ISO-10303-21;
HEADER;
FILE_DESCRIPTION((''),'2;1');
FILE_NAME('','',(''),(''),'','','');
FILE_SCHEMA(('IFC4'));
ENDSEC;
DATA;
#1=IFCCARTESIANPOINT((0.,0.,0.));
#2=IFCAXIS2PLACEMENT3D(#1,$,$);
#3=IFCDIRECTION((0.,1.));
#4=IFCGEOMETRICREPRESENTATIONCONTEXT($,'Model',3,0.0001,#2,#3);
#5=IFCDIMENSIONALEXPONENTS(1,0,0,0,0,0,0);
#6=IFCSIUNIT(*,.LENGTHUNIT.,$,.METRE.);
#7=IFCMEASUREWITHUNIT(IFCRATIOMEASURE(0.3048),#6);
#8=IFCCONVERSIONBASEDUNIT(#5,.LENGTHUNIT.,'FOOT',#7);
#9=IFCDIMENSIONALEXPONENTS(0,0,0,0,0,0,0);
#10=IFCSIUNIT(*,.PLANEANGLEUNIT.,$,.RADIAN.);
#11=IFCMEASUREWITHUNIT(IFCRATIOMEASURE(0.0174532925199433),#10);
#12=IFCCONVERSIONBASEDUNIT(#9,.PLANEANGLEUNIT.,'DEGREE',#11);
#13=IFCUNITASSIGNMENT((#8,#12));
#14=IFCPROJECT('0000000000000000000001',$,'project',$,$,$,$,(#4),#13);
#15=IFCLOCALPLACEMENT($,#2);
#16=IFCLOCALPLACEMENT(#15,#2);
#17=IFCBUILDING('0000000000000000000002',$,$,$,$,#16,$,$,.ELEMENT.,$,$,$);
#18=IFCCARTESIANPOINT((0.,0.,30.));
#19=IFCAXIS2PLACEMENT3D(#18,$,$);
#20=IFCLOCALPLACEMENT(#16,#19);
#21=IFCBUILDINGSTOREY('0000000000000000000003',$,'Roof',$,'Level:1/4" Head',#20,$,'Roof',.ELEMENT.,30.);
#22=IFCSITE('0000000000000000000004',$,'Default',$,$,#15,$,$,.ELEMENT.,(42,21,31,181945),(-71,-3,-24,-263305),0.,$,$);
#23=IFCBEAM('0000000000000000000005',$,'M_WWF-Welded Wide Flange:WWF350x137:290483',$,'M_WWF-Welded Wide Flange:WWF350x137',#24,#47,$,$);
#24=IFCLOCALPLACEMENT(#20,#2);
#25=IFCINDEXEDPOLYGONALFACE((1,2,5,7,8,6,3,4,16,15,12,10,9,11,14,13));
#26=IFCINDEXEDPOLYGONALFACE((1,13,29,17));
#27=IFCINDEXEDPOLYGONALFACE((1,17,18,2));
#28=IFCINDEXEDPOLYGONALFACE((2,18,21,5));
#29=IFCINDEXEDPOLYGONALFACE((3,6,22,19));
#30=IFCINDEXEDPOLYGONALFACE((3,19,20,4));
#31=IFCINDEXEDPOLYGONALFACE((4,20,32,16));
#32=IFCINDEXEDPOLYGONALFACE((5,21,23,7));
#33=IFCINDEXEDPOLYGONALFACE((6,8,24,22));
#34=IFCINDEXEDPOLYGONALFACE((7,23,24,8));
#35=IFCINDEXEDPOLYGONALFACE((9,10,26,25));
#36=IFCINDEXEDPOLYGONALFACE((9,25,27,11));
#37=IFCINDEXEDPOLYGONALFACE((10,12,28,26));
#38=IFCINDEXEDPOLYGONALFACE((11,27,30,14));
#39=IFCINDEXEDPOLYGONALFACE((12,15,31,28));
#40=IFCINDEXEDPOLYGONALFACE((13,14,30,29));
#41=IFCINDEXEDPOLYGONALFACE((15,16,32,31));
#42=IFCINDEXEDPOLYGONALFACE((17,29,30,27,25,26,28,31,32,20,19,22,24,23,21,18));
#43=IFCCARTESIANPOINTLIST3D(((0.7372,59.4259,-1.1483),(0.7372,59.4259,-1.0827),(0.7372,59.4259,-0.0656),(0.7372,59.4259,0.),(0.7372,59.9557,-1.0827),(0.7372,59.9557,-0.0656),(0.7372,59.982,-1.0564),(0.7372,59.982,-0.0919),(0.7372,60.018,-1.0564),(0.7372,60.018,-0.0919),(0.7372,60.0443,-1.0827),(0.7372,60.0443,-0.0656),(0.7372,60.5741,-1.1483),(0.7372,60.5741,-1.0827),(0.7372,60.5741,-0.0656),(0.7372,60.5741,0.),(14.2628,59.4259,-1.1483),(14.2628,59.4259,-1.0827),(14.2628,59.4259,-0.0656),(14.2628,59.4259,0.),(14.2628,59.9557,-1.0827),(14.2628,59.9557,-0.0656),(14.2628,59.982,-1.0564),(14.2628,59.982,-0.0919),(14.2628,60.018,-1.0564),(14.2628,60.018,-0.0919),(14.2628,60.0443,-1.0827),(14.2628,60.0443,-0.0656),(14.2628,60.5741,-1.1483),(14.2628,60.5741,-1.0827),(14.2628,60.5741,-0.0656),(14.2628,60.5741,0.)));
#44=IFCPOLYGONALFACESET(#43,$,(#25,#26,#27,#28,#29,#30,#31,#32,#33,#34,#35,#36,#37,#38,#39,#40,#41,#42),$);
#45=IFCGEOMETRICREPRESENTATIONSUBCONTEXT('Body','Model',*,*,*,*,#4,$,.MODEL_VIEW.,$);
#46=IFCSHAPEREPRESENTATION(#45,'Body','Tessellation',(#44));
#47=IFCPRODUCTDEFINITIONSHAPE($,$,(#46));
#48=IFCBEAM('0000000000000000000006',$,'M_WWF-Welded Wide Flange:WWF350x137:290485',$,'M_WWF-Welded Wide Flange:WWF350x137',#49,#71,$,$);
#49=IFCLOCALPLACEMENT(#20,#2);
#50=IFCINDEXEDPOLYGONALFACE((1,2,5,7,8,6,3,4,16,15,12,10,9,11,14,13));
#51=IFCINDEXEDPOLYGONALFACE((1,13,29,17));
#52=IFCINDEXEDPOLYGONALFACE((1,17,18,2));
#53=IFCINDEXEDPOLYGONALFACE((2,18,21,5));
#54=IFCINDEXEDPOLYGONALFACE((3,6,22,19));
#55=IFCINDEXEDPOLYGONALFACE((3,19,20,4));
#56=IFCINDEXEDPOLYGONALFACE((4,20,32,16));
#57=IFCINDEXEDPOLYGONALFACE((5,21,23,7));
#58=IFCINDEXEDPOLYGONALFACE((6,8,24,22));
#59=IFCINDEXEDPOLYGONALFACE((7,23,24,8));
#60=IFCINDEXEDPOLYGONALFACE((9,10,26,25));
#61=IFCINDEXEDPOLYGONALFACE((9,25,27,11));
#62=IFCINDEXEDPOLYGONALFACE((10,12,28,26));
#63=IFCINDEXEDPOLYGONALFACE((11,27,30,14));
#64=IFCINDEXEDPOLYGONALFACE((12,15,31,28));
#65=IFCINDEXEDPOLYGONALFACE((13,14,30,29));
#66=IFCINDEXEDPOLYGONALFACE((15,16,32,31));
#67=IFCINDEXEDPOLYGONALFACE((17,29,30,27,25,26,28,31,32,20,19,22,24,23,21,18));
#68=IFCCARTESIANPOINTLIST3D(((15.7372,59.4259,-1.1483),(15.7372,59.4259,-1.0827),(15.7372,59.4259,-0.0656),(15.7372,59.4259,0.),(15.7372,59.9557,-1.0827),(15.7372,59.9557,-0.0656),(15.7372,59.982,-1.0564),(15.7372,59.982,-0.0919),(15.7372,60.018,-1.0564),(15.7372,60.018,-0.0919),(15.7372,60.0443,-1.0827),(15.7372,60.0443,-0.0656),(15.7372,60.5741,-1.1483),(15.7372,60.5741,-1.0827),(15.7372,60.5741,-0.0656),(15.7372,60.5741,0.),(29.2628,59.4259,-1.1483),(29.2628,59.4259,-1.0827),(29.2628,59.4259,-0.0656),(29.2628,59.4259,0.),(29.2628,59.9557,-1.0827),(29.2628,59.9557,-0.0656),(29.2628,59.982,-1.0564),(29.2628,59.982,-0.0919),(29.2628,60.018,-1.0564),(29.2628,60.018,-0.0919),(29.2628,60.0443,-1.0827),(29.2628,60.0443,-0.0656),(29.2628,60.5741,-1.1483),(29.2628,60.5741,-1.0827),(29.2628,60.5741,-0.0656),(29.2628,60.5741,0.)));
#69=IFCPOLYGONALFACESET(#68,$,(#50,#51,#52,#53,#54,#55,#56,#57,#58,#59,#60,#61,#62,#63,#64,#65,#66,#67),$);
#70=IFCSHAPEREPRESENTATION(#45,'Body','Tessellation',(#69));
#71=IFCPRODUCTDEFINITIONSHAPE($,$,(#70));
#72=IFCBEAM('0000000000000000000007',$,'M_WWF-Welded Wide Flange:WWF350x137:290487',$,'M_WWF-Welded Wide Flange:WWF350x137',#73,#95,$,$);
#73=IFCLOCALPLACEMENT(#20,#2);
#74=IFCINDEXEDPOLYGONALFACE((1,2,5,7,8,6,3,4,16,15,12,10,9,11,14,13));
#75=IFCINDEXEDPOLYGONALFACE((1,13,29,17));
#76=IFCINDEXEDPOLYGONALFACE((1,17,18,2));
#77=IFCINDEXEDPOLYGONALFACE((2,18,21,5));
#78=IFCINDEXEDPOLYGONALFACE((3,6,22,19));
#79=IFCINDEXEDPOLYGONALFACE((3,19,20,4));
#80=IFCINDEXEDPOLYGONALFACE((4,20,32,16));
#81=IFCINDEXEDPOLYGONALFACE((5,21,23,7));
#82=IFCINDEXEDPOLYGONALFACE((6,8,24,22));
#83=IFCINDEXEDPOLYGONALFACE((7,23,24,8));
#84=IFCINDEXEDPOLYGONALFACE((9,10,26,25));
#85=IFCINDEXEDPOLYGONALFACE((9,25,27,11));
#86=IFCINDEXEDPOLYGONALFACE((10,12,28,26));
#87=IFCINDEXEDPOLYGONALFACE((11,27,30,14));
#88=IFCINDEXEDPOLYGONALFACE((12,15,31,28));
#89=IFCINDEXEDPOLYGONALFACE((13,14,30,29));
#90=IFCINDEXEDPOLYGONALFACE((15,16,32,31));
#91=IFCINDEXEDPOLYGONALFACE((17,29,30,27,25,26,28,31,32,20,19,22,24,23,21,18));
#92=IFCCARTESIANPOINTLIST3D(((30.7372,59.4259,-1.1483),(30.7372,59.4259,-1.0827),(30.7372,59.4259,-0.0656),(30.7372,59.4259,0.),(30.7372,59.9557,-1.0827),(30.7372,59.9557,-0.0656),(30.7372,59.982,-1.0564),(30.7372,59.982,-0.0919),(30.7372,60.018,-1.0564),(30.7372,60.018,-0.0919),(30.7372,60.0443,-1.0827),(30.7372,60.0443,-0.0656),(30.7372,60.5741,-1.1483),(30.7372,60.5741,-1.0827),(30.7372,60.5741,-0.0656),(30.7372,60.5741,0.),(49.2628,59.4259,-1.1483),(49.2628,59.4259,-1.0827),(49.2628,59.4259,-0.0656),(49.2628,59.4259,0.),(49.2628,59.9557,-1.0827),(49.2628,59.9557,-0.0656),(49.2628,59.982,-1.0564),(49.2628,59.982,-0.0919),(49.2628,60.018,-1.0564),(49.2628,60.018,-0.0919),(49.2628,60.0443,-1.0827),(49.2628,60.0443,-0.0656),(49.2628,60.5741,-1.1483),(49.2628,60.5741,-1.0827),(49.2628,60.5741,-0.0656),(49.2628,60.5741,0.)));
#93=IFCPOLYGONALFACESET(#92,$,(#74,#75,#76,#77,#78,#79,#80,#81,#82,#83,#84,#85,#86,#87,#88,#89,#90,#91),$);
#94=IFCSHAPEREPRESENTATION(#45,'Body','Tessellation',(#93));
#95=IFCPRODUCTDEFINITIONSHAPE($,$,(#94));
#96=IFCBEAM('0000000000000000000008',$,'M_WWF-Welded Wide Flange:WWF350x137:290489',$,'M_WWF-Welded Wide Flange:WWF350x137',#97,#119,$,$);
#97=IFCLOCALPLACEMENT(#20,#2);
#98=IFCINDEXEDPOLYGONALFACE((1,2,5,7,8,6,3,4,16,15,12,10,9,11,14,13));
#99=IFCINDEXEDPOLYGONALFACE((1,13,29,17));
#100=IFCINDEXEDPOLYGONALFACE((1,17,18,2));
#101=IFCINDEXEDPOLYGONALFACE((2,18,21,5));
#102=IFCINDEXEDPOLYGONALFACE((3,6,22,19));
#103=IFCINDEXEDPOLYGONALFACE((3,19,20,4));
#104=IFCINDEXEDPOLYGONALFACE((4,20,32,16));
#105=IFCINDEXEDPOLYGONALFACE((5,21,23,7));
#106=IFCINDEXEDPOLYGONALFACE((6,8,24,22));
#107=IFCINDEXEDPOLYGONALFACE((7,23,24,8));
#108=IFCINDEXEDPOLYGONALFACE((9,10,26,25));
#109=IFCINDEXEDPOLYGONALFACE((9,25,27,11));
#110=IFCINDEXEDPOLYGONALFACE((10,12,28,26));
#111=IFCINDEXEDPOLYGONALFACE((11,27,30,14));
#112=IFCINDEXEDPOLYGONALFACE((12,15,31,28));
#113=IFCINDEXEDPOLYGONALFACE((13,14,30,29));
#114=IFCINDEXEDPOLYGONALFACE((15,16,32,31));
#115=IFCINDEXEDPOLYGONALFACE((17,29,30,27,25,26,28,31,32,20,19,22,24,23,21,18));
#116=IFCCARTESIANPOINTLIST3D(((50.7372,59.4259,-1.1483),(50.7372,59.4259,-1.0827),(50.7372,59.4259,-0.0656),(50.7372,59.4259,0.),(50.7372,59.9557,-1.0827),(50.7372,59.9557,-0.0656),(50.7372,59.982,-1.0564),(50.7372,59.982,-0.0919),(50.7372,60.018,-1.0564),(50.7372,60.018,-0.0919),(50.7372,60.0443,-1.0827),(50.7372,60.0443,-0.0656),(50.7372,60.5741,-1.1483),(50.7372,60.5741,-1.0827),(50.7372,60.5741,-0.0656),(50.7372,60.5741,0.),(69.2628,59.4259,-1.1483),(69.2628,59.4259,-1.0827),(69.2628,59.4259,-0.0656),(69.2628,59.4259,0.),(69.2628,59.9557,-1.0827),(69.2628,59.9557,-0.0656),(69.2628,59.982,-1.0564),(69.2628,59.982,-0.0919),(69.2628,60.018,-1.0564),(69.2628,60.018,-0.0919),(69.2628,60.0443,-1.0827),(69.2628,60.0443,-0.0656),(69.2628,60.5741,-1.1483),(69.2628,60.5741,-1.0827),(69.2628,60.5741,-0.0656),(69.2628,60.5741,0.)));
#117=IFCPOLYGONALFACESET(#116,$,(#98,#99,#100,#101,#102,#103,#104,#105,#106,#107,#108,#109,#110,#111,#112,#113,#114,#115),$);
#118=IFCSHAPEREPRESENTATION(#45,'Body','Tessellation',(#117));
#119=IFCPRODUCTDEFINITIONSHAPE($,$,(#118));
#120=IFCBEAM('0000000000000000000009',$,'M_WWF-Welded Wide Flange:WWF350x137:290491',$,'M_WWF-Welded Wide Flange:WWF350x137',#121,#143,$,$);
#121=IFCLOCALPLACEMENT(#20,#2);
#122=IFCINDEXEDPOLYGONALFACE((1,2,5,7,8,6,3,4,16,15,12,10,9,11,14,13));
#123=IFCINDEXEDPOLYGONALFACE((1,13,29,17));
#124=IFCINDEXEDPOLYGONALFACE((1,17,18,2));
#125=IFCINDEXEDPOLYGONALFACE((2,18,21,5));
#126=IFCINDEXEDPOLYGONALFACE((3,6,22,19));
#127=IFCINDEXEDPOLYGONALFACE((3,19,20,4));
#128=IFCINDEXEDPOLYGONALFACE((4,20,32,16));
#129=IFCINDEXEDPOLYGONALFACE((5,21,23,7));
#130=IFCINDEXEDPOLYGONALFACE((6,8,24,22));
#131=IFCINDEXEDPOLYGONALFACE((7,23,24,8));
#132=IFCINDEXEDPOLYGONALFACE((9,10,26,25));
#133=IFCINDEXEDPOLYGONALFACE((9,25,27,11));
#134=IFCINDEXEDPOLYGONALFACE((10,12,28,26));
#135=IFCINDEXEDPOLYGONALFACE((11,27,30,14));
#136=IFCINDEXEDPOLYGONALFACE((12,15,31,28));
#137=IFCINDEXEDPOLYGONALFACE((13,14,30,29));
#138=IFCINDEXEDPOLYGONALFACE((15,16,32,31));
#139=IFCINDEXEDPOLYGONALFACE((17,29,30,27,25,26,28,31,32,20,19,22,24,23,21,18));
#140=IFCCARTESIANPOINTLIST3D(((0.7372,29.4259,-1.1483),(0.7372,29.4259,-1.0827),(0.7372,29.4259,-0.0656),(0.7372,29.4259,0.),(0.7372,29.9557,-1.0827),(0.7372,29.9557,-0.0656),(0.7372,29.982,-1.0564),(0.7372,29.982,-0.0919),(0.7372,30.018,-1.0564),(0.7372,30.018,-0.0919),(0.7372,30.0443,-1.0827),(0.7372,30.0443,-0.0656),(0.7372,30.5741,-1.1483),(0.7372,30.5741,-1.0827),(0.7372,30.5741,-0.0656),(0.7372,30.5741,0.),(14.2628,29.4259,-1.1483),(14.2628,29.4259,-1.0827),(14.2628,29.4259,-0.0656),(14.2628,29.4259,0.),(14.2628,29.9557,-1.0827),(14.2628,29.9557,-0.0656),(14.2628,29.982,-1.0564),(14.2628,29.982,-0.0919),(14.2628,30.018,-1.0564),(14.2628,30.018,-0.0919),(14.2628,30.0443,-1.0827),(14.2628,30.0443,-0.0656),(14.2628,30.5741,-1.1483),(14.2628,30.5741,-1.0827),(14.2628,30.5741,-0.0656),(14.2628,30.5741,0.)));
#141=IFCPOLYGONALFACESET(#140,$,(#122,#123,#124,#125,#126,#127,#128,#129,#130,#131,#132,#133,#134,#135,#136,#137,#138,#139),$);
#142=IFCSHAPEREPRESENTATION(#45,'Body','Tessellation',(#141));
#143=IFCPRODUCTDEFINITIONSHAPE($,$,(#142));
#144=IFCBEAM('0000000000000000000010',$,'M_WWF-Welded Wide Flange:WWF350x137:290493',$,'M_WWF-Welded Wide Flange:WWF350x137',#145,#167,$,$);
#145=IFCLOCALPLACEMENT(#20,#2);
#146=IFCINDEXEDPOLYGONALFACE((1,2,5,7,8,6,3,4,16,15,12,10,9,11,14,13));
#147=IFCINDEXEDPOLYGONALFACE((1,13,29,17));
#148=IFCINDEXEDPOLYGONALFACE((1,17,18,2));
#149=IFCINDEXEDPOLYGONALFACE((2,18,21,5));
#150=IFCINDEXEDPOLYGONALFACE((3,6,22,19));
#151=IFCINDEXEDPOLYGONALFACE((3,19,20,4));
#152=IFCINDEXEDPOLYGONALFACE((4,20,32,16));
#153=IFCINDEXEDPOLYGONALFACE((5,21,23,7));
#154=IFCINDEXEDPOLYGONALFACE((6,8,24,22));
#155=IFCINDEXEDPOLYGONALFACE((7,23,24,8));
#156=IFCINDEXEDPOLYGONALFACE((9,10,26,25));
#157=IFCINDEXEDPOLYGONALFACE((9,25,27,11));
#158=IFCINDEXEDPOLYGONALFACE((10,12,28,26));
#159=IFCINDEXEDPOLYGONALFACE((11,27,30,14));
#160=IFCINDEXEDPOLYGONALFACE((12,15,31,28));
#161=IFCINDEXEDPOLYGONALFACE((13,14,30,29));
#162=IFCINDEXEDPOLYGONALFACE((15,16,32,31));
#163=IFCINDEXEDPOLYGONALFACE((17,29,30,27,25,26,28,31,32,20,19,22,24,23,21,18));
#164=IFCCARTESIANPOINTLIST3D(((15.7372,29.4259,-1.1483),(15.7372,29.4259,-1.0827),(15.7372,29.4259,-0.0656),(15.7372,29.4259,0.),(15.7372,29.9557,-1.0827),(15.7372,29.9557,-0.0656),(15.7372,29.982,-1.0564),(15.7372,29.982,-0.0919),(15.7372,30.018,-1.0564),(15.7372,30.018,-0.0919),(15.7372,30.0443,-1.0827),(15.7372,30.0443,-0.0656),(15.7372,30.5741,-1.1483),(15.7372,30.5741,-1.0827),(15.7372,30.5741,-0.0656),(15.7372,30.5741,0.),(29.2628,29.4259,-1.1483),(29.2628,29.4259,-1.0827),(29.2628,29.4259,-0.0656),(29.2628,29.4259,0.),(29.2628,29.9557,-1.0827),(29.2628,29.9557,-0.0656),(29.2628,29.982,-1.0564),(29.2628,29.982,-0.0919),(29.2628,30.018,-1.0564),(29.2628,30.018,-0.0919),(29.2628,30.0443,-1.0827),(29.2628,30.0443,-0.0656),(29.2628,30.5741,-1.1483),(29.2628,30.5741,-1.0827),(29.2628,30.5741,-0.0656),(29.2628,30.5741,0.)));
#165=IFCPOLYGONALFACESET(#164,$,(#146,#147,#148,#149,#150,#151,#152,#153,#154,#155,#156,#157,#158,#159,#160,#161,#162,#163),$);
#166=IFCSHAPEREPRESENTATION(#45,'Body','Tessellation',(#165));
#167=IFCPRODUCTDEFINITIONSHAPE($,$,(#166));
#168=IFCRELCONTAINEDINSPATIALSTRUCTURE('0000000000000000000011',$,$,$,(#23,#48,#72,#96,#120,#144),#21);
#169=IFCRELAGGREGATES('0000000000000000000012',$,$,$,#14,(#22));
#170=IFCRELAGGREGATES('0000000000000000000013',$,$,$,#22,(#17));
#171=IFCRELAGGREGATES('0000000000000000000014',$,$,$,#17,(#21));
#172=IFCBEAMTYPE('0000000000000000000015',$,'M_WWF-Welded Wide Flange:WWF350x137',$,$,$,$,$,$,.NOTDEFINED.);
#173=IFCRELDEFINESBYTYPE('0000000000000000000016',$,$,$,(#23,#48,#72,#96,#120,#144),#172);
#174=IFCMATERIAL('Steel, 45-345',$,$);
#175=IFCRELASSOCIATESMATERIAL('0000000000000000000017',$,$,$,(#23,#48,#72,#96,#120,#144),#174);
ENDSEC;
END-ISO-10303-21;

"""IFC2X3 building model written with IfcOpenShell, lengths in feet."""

from ifc_helpers import new_model, entity, si_unit, converted_unit, direction, frame, origin, place, context, subcontext, project, spatial, polyline, outline, extrude, material, type_object, element, save


model = new_model("IFC2X3")

# Units and contexts
model_context = context("Model", 3, precision=0.0001, world=origin(), true_north=direction((0.0, 1.0)))
body_context = subcontext(model_context, "Body", "Model", "MODEL_VIEW")
ifc_project = project(units=[converted_unit("LENGTHUNIT", "FOOT", entity("IfcRatioMeasure", 0.3048), si_unit("LENGTHUNIT", "METRE"), dimensions=[1, 0, 0, 0, 0, 0, 0]), converted_unit("PLANEANGLEUNIT", "DEGREE", entity("IfcRatioMeasure", 0.0174532925199433), si_unit("PLANEANGLEUNIT", "RADIAN"), dimensions=[0, 0, 0, 0, 0, 0, 0])], contexts=[model_context])

# Site, building, storey
site_placement = place(None, origin())
site = spatial("IfcSite", under=ifc_project, at=site_placement, Name="Default", CompositionType="ELEMENT", RefLatitude=(42, 21, 31, 181945), RefLongitude=(-71, -3, -24, -263305), RefElevation=0.0)
building_placement = place(site_placement, origin())
building = spatial("IfcBuilding", under=site, at=building_placement, CompositionType="ELEMENT")
storey_placement = place(building_placement, frame((0.0, 0.0, 30.0)))
storey = spatial("IfcBuildingStorey", under=building, at=storey_placement, Name="Roof", ObjectType="Level:1/4\" Head", LongName="Roof", CompositionType="ELEMENT", Elevation=30.0)

# Beams
ifc_material = material(Name="Steel, 45-345")
beam_type = type_object("IfcBeamType", Name="M_WWF-Welded Wide Flange:WWF350x137", PredefinedType="NOTDEFINED")
beam_1_placement = place(storey_placement, frame((0.0, 60.0, 0.0)))
element("IfcBeam", 1, at=beam_1_placement, inside=storey, type_object=beam_type, material=ifc_material, Name="M_WWF-Welded Wide Flange:WWF350x137:290483", ObjectType="M_WWF-Welded Wide Flange:WWF350x137", context=body_context, shape_type="SweptSolid", body=[
    extrude(outline(polyline([(-0.5741, -0.5741), (-0.5085, -0.5741), (-0.5085, -0.0443), (-0.4823, -0.018), (0.4823, -0.018), (0.5085, -0.0443), (0.5085, -0.5741), (0.5741, -0.5741), (0.5741, 0.5741), (0.5085, 0.5741), (0.5085, 0.0443), (0.4823, 0.018), (-0.4823, 0.018), (-0.5085, 0.0443), (-0.5085, 0.5741), (-0.5741, 0.5741), (-0.5741, -0.5741)])), frame((0.7372, 0.0, -0.5741), z_axis=(1.0, 0.0, 0.0), x_axis=(0.0, 0.0, -1.0)), (0.0, 0.0, 1.0), 13.5256),
])
beam_2_placement = place(storey_placement, frame((15.0, 60.0, 0.0)))
element("IfcBeam", 2, at=beam_2_placement, inside=storey, type_object=beam_type, material=ifc_material, Name="M_WWF-Welded Wide Flange:WWF350x137:290485", ObjectType="M_WWF-Welded Wide Flange:WWF350x137", context=body_context, shape_type="SweptSolid", body=[
    extrude(outline(polyline([(-0.5741, -0.5741), (-0.5085, -0.5741), (-0.5085, -0.0443), (-0.4823, -0.018), (0.4823, -0.018), (0.5085, -0.0443), (0.5085, -0.5741), (0.5741, -0.5741), (0.5741, 0.5741), (0.5085, 0.5741), (0.5085, 0.0443), (0.4823, 0.018), (-0.4823, 0.018), (-0.5085, 0.0443), (-0.5085, 0.5741), (-0.5741, 0.5741), (-0.5741, -0.5741)])), frame((0.7372, 0.0, -0.5741), z_axis=(1.0, 0.0, 0.0), x_axis=(0.0, 0.0, -1.0)), (0.0, 0.0, 1.0), 13.5256),
])
beam_3_placement = place(storey_placement, frame((30.0, 60.0, 0.0)))
element("IfcBeam", 3, at=beam_3_placement, inside=storey, type_object=beam_type, material=ifc_material, Name="M_WWF-Welded Wide Flange:WWF350x137:290487", ObjectType="M_WWF-Welded Wide Flange:WWF350x137", context=body_context, shape_type="SweptSolid", body=[
    extrude(outline(polyline([(-0.5741, -0.5741), (-0.5085, -0.5741), (-0.5085, -0.0443), (-0.4823, -0.018), (0.4823, -0.018), (0.5085, -0.0443), (0.5085, -0.5741), (0.5741, -0.5741), (0.5741, 0.5741), (0.5085, 0.5741), (0.5085, 0.0443), (0.4823, 0.018), (-0.4823, 0.018), (-0.5085, 0.0443), (-0.5085, 0.5741), (-0.5741, 0.5741), (-0.5741, -0.5741)])), frame((0.7372, 0.0, -0.5741), z_axis=(1.0, 0.0, 0.0), x_axis=(0.0, 0.0, -1.0)), (0.0, 0.0, 1.0), 18.5256),
])
beam_4_placement = place(storey_placement, frame((50.0, 60.0, 0.0)))
element("IfcBeam", 4, at=beam_4_placement, inside=storey, type_object=beam_type, material=ifc_material, Name="M_WWF-Welded Wide Flange:WWF350x137:290489", ObjectType="M_WWF-Welded Wide Flange:WWF350x137", context=body_context, shape_type="SweptSolid", body=[
    extrude(outline(polyline([(-0.5741, -0.5741), (-0.5085, -0.5741), (-0.5085, -0.0443), (-0.4823, -0.018), (0.4823, -0.018), (0.5085, -0.0443), (0.5085, -0.5741), (0.5741, -0.5741), (0.5741, 0.5741), (0.5085, 0.5741), (0.5085, 0.0443), (0.4823, 0.018), (-0.4823, 0.018), (-0.5085, 0.0443), (-0.5085, 0.5741), (-0.5741, 0.5741), (-0.5741, -0.5741)])), frame((0.7372, 0.0, -0.5741), z_axis=(1.0, 0.0, 0.0), x_axis=(0.0, 0.0, -1.0)), (0.0, 0.0, 1.0), 18.5256),
])
beam_5_placement = place(storey_placement, frame((0.0, 30.0, 0.0)))
element("IfcBeam", 5, at=beam_5_placement, inside=storey, type_object=beam_type, material=ifc_material, Name="M_WWF-Welded Wide Flange:WWF350x137:290491", ObjectType="M_WWF-Welded Wide Flange:WWF350x137", context=body_context, shape_type="SweptSolid", body=[
    extrude(outline(polyline([(-0.5741, -0.5741), (-0.5085, -0.5741), (-0.5085, -0.0443), (-0.4823, -0.018), (0.4823, -0.018), (0.5085, -0.0443), (0.5085, -0.5741), (0.5741, -0.5741), (0.5741, 0.5741), (0.5085, 0.5741), (0.5085, 0.0443), (0.4823, 0.018), (-0.4823, 0.018), (-0.5085, 0.0443), (-0.5085, 0.5741), (-0.5741, 0.5741), (-0.5741, -0.5741)])), frame((0.7372, 0.0, -0.5741), z_axis=(1.0, 0.0, 0.0), x_axis=(0.0, 0.0, -1.0)), (0.0, 0.0, 1.0), 13.5256),
])
beam_6_placement = place(storey_placement, frame((15.0, 30.0, 0.0)))
element("IfcBeam", 6, at=beam_6_placement, inside=storey, type_object=beam_type, material=ifc_material, Name="M_WWF-Welded Wide Flange:WWF350x137:290493", ObjectType="M_WWF-Welded Wide Flange:WWF350x137", context=body_context, shape_type="SweptSolid", body=[
    extrude(outline(polyline([(-0.5741, -0.5741), (-0.5085, -0.5741), (-0.5085, -0.0443), (-0.4823, -0.018), (0.4823, -0.018), (0.5085, -0.0443), (0.5085, -0.5741), (0.5741, -0.5741), (0.5741, 0.5741), (0.5085, 0.5741), (0.5085, 0.0443), (0.4823, 0.018), (-0.4823, 0.018), (-0.5085, 0.0443), (-0.5085, 0.5741), (-0.5741, 0.5741), (-0.5741, -0.5741)])), frame((0.7372, 0.0, -0.5741), z_axis=(1.0, 0.0, 0.0), x_axis=(0.0, 0.0, -1.0)), (0.0, 0.0, 1.0), 13.5256),
])

save(model, "model.ifc")
